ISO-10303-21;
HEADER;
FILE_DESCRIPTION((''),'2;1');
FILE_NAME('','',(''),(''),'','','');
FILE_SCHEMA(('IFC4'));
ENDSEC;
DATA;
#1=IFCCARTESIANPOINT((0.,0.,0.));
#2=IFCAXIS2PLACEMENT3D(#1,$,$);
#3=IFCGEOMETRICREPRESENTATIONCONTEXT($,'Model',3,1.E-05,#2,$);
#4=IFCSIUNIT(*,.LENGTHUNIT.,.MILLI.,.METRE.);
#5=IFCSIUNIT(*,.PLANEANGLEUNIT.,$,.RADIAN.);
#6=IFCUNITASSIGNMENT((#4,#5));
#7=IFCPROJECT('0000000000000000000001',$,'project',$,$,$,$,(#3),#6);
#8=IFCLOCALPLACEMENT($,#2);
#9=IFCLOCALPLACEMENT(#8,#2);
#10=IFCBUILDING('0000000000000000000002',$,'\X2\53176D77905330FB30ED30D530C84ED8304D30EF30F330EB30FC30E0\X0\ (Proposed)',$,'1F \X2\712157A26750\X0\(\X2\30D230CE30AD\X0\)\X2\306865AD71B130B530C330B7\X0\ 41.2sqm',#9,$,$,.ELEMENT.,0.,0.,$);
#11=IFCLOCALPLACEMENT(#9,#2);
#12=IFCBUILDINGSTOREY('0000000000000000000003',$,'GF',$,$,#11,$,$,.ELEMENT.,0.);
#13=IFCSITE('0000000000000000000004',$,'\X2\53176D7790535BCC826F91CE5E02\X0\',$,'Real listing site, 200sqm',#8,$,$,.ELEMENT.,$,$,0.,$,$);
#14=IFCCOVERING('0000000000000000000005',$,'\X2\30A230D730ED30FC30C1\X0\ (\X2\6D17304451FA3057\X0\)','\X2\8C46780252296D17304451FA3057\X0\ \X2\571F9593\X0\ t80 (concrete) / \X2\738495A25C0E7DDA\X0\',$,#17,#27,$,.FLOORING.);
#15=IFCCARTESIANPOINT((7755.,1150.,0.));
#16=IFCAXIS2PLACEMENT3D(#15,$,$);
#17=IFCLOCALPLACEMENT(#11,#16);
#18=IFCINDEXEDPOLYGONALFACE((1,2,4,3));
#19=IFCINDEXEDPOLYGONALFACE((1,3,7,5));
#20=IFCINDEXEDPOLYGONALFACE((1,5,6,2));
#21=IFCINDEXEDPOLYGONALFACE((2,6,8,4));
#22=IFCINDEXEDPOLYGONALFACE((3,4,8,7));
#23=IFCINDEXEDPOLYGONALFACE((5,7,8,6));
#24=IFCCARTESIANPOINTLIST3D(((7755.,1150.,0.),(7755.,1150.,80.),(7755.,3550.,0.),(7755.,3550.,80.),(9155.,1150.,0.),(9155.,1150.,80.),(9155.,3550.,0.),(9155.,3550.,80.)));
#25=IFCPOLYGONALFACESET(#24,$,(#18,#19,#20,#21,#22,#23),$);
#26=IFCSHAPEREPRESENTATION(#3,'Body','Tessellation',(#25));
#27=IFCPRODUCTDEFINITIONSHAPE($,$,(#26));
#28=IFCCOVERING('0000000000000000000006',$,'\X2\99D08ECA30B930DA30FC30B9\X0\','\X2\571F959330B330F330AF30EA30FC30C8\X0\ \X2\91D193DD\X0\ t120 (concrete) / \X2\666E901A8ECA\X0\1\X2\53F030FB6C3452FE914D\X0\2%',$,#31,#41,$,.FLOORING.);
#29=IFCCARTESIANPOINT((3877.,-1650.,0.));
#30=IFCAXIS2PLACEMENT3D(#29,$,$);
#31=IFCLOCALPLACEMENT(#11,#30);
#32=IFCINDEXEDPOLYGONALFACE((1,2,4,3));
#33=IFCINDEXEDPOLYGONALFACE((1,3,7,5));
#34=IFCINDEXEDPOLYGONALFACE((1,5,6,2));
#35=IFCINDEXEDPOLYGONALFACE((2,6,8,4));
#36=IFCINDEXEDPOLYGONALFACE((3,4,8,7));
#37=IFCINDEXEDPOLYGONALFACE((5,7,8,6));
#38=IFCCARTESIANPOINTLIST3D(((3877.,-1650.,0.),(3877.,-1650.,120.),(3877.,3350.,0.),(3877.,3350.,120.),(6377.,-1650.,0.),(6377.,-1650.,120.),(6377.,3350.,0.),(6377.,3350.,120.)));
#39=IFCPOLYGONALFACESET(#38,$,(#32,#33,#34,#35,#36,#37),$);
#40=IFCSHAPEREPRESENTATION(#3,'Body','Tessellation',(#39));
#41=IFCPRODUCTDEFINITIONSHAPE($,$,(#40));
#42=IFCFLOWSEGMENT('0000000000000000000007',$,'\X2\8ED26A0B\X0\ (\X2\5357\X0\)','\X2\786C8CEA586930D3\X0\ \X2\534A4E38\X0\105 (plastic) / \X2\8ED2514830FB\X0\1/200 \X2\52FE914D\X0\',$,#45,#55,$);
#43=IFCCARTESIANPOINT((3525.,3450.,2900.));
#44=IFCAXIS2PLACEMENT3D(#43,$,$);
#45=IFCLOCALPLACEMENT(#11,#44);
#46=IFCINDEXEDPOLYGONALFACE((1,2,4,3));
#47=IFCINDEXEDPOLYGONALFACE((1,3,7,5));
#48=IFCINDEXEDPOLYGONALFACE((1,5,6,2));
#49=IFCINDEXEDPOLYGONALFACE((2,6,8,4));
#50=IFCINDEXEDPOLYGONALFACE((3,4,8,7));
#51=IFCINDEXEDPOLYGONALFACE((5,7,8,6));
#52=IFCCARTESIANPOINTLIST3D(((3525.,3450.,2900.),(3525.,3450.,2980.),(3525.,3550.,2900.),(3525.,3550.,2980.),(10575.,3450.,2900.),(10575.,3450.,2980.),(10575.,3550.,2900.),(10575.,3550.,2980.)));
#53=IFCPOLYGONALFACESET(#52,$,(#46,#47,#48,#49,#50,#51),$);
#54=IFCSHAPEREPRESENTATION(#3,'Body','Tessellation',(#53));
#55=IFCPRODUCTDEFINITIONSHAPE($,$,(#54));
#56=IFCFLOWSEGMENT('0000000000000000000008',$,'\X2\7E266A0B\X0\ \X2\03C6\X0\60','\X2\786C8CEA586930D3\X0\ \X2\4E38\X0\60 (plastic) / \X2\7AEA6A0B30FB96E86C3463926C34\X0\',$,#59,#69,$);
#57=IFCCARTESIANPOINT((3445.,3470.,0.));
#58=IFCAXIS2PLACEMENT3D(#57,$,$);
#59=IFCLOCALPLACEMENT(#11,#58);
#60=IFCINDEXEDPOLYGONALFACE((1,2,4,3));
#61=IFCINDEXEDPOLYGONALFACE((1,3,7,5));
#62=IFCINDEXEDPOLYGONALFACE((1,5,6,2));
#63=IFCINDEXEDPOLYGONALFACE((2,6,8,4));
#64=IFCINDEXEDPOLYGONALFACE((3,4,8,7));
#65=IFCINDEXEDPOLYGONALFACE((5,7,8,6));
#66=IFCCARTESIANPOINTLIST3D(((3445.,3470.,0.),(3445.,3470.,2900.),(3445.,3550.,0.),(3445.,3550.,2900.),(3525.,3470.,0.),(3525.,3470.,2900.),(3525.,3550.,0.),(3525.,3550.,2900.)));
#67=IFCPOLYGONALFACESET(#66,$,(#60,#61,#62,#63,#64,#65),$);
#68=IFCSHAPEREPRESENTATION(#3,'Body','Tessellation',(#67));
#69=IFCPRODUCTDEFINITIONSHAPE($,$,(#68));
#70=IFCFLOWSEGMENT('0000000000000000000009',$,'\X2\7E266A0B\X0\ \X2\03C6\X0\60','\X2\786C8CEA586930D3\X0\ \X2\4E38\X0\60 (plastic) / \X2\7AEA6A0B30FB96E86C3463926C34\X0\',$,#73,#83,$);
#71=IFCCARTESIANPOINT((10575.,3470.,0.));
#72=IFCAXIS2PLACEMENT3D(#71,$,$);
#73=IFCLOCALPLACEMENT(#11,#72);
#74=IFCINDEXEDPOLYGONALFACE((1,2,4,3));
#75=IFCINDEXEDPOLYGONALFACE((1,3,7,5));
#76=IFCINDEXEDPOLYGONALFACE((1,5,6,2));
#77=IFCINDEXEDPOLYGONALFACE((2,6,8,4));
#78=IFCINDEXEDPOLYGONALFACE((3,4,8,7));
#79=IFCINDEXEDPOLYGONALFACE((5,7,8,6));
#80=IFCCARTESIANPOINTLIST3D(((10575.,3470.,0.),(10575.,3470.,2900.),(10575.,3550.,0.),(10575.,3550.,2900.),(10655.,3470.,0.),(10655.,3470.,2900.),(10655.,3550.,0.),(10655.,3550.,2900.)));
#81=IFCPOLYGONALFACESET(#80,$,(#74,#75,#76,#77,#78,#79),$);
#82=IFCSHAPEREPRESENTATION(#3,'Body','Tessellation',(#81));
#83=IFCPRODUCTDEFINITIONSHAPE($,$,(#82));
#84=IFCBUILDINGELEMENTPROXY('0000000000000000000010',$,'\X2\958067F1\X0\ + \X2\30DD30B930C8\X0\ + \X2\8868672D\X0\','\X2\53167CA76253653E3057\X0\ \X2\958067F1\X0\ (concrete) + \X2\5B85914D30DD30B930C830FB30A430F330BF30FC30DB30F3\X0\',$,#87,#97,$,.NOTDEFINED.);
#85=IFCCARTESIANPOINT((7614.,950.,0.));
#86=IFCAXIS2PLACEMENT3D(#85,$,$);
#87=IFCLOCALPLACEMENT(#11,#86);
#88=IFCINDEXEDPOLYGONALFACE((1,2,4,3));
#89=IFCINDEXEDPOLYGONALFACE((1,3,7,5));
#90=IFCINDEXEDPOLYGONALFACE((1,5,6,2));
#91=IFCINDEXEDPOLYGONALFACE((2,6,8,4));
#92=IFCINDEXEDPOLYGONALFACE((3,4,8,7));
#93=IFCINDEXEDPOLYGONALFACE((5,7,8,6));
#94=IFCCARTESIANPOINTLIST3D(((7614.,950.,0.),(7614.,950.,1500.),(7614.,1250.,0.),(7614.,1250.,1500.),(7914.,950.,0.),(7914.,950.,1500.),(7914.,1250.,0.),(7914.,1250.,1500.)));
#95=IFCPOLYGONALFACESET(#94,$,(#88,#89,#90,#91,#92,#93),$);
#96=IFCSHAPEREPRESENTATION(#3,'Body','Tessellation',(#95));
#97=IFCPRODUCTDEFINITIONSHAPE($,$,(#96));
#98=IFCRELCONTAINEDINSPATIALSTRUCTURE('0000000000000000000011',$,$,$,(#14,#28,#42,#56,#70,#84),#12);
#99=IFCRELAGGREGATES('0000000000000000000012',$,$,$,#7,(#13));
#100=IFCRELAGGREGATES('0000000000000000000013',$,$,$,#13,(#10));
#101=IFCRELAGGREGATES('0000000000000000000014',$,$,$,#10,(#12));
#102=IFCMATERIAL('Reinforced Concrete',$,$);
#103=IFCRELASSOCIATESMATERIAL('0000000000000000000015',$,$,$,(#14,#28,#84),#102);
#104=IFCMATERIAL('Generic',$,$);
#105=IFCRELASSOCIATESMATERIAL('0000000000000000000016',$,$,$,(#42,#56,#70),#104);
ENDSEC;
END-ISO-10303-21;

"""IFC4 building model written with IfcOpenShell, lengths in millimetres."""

from ifc_helpers import new_model, si_unit, frame, frame_2d, origin, place, context, project, spatial, rectangle, extrude, material, element, save


model = new_model("IFC4")

# Units and contexts
model_context = context("Model", 3, precision=1e-05, world=origin())
ifc_project = project(units=[si_unit("LENGTHUNIT", "METRE", prefix="MILLI"), si_unit("PLANEANGLEUNIT", "RADIAN")], contexts=[model_context])

# Site, building, storey
site_placement = place(None, origin())
site = spatial("IfcSite", under=ifc_project, at=site_placement, Name="北海道富良野市", ObjectType="Real listing site, 200sqm", CompositionType="ELEMENT", RefElevation=0.0)
building_placement = place(site_placement, origin())
building = spatial("IfcBuilding", under=site, at=building_placement, Name="北海道・ロフト付きワンルーム (Proposed)", ObjectType="1F 無垢材(ヒノキ)と断熱サッシ 41.2sqm", CompositionType="ELEMENT", ElevationOfRefHeight=0.0, ElevationOfTerrain=0.0)
storey_placement = place(building_placement, origin())
storey = spatial("IfcBuildingStorey", under=building, at=storey_placement, Name="GF", CompositionType="ELEMENT", Elevation=0.0)

# Shared definitions
ifc_material_1 = material(Name="Reinforced Concrete")

# Coverings
ifc_material_2 = material(Name="Generic")
covering_1_placement = place(storey_placement, frame((7755.0, 1150.0, 0.0)))
element("IfcCovering", 1, at=covering_1_placement, inside=storey, material=ifc_material_1, Name="アプローチ (洗い出し)", Description="豆砂利洗い出し 土間 t80 (concrete) / 玄関導線", PredefinedType="FLOORING", context=model_context, shape_type="SweptSolid", body=[
    extrude(rectangle(XDim=1400.0, YDim=2400.0, at=frame_2d((700.0, 1200.0))), frame((7755.0, 1150.0, 0.0)), (0.0, 0.0, 1.0), 80.0),
])
covering_2_placement = place(storey_placement, frame((3877.0, -1650.0, 0.0)))
element("IfcCovering", 2, at=covering_2_placement, inside=storey, material=ifc_material_1, Name="駐車スペース", Description="土間コンクリート 金鏝 t120 (concrete) / 普通車1台・水勾配2%", PredefinedType="FLOORING", context=model_context, shape_type="SweptSolid", body=[
    extrude(rectangle(XDim=2500.0, YDim=5000.0, at=frame_2d((1250.0, 2500.0))), frame((3877.0, -1650.0, 0.0)), (0.0, 0.0, 1.0), 120.0),
])

# Flow segments
flow_segment_1_placement = place(storey_placement, frame((3525.0, 3450.0, 2900.0)))
element("IfcFlowSegment", 3, at=flow_segment_1_placement, inside=storey, material=ifc_material_2, Name="軒樋 (南)", Description="硬質塩ビ 半丸105 (plastic) / 軒先・1/200 勾配", context=model_context, shape_type="SweptSolid", body=[
    extrude(rectangle(XDim=7050.0, YDim=100.0, at=frame_2d((3525.0, 50.0))), frame((3525.0, 3450.0, 2900.0)), (0.0, 0.0, 1.0), 80.0),
])
flow_segment_2_placement = place(storey_placement, frame((3445.0, 3470.0, 0.0)))
element("IfcFlowSegment", 4, at=flow_segment_2_placement, inside=storey, material=ifc_material_2, Name="縦樋 φ60", Description="硬質塩ビ 丸60 (plastic) / 竪樋・雨水排水", context=model_context, shape_type="SweptSolid", body=[
    extrude(rectangle(XDim=80.0, YDim=80.0, at=frame_2d((40.0, 40.0))), frame((3445.0, 3470.0, 0.0)), (0.0, 0.0, 1.0), 2900.0),
])
flow_segment_3_placement = place(storey_placement, frame((10575.0, 3470.0, 0.0)))
element("IfcFlowSegment", 5, at=flow_segment_3_placement, inside=storey, material=ifc_material_2, Name="縦樋 φ60", Description="硬質塩ビ 丸60 (plastic) / 竪樋・雨水排水", context=model_context, shape_type="SweptSolid", body=[
    extrude(rectangle(XDim=80.0, YDim=80.0, at=frame_2d((40.0, 40.0))), frame((10575.0, 3470.0, 0.0)), (0.0, 0.0, 1.0), 2900.0),
])

# Building element proxy
proxy_placement = place(storey_placement, frame((7614.0, 950.0, 0.0)))
element("IfcBuildingElementProxy", 6, at=proxy_placement, inside=storey, material=ifc_material_1, Name="門柱 + ポスト + 表札", Description="化粧打放し 門柱 (concrete) + 宅配ポスト・インターホン", PredefinedType="NOTDEFINED", context=model_context, shape_type="SweptSolid", body=[
    extrude(rectangle(XDim=300.0, YDim=300.0, at=frame_2d((150.0, 150.0))), frame((7614.0, 950.0, 0.0)), (0.0, 0.0, 1.0), 1500.0),
])

save(model, "model.ifc")
